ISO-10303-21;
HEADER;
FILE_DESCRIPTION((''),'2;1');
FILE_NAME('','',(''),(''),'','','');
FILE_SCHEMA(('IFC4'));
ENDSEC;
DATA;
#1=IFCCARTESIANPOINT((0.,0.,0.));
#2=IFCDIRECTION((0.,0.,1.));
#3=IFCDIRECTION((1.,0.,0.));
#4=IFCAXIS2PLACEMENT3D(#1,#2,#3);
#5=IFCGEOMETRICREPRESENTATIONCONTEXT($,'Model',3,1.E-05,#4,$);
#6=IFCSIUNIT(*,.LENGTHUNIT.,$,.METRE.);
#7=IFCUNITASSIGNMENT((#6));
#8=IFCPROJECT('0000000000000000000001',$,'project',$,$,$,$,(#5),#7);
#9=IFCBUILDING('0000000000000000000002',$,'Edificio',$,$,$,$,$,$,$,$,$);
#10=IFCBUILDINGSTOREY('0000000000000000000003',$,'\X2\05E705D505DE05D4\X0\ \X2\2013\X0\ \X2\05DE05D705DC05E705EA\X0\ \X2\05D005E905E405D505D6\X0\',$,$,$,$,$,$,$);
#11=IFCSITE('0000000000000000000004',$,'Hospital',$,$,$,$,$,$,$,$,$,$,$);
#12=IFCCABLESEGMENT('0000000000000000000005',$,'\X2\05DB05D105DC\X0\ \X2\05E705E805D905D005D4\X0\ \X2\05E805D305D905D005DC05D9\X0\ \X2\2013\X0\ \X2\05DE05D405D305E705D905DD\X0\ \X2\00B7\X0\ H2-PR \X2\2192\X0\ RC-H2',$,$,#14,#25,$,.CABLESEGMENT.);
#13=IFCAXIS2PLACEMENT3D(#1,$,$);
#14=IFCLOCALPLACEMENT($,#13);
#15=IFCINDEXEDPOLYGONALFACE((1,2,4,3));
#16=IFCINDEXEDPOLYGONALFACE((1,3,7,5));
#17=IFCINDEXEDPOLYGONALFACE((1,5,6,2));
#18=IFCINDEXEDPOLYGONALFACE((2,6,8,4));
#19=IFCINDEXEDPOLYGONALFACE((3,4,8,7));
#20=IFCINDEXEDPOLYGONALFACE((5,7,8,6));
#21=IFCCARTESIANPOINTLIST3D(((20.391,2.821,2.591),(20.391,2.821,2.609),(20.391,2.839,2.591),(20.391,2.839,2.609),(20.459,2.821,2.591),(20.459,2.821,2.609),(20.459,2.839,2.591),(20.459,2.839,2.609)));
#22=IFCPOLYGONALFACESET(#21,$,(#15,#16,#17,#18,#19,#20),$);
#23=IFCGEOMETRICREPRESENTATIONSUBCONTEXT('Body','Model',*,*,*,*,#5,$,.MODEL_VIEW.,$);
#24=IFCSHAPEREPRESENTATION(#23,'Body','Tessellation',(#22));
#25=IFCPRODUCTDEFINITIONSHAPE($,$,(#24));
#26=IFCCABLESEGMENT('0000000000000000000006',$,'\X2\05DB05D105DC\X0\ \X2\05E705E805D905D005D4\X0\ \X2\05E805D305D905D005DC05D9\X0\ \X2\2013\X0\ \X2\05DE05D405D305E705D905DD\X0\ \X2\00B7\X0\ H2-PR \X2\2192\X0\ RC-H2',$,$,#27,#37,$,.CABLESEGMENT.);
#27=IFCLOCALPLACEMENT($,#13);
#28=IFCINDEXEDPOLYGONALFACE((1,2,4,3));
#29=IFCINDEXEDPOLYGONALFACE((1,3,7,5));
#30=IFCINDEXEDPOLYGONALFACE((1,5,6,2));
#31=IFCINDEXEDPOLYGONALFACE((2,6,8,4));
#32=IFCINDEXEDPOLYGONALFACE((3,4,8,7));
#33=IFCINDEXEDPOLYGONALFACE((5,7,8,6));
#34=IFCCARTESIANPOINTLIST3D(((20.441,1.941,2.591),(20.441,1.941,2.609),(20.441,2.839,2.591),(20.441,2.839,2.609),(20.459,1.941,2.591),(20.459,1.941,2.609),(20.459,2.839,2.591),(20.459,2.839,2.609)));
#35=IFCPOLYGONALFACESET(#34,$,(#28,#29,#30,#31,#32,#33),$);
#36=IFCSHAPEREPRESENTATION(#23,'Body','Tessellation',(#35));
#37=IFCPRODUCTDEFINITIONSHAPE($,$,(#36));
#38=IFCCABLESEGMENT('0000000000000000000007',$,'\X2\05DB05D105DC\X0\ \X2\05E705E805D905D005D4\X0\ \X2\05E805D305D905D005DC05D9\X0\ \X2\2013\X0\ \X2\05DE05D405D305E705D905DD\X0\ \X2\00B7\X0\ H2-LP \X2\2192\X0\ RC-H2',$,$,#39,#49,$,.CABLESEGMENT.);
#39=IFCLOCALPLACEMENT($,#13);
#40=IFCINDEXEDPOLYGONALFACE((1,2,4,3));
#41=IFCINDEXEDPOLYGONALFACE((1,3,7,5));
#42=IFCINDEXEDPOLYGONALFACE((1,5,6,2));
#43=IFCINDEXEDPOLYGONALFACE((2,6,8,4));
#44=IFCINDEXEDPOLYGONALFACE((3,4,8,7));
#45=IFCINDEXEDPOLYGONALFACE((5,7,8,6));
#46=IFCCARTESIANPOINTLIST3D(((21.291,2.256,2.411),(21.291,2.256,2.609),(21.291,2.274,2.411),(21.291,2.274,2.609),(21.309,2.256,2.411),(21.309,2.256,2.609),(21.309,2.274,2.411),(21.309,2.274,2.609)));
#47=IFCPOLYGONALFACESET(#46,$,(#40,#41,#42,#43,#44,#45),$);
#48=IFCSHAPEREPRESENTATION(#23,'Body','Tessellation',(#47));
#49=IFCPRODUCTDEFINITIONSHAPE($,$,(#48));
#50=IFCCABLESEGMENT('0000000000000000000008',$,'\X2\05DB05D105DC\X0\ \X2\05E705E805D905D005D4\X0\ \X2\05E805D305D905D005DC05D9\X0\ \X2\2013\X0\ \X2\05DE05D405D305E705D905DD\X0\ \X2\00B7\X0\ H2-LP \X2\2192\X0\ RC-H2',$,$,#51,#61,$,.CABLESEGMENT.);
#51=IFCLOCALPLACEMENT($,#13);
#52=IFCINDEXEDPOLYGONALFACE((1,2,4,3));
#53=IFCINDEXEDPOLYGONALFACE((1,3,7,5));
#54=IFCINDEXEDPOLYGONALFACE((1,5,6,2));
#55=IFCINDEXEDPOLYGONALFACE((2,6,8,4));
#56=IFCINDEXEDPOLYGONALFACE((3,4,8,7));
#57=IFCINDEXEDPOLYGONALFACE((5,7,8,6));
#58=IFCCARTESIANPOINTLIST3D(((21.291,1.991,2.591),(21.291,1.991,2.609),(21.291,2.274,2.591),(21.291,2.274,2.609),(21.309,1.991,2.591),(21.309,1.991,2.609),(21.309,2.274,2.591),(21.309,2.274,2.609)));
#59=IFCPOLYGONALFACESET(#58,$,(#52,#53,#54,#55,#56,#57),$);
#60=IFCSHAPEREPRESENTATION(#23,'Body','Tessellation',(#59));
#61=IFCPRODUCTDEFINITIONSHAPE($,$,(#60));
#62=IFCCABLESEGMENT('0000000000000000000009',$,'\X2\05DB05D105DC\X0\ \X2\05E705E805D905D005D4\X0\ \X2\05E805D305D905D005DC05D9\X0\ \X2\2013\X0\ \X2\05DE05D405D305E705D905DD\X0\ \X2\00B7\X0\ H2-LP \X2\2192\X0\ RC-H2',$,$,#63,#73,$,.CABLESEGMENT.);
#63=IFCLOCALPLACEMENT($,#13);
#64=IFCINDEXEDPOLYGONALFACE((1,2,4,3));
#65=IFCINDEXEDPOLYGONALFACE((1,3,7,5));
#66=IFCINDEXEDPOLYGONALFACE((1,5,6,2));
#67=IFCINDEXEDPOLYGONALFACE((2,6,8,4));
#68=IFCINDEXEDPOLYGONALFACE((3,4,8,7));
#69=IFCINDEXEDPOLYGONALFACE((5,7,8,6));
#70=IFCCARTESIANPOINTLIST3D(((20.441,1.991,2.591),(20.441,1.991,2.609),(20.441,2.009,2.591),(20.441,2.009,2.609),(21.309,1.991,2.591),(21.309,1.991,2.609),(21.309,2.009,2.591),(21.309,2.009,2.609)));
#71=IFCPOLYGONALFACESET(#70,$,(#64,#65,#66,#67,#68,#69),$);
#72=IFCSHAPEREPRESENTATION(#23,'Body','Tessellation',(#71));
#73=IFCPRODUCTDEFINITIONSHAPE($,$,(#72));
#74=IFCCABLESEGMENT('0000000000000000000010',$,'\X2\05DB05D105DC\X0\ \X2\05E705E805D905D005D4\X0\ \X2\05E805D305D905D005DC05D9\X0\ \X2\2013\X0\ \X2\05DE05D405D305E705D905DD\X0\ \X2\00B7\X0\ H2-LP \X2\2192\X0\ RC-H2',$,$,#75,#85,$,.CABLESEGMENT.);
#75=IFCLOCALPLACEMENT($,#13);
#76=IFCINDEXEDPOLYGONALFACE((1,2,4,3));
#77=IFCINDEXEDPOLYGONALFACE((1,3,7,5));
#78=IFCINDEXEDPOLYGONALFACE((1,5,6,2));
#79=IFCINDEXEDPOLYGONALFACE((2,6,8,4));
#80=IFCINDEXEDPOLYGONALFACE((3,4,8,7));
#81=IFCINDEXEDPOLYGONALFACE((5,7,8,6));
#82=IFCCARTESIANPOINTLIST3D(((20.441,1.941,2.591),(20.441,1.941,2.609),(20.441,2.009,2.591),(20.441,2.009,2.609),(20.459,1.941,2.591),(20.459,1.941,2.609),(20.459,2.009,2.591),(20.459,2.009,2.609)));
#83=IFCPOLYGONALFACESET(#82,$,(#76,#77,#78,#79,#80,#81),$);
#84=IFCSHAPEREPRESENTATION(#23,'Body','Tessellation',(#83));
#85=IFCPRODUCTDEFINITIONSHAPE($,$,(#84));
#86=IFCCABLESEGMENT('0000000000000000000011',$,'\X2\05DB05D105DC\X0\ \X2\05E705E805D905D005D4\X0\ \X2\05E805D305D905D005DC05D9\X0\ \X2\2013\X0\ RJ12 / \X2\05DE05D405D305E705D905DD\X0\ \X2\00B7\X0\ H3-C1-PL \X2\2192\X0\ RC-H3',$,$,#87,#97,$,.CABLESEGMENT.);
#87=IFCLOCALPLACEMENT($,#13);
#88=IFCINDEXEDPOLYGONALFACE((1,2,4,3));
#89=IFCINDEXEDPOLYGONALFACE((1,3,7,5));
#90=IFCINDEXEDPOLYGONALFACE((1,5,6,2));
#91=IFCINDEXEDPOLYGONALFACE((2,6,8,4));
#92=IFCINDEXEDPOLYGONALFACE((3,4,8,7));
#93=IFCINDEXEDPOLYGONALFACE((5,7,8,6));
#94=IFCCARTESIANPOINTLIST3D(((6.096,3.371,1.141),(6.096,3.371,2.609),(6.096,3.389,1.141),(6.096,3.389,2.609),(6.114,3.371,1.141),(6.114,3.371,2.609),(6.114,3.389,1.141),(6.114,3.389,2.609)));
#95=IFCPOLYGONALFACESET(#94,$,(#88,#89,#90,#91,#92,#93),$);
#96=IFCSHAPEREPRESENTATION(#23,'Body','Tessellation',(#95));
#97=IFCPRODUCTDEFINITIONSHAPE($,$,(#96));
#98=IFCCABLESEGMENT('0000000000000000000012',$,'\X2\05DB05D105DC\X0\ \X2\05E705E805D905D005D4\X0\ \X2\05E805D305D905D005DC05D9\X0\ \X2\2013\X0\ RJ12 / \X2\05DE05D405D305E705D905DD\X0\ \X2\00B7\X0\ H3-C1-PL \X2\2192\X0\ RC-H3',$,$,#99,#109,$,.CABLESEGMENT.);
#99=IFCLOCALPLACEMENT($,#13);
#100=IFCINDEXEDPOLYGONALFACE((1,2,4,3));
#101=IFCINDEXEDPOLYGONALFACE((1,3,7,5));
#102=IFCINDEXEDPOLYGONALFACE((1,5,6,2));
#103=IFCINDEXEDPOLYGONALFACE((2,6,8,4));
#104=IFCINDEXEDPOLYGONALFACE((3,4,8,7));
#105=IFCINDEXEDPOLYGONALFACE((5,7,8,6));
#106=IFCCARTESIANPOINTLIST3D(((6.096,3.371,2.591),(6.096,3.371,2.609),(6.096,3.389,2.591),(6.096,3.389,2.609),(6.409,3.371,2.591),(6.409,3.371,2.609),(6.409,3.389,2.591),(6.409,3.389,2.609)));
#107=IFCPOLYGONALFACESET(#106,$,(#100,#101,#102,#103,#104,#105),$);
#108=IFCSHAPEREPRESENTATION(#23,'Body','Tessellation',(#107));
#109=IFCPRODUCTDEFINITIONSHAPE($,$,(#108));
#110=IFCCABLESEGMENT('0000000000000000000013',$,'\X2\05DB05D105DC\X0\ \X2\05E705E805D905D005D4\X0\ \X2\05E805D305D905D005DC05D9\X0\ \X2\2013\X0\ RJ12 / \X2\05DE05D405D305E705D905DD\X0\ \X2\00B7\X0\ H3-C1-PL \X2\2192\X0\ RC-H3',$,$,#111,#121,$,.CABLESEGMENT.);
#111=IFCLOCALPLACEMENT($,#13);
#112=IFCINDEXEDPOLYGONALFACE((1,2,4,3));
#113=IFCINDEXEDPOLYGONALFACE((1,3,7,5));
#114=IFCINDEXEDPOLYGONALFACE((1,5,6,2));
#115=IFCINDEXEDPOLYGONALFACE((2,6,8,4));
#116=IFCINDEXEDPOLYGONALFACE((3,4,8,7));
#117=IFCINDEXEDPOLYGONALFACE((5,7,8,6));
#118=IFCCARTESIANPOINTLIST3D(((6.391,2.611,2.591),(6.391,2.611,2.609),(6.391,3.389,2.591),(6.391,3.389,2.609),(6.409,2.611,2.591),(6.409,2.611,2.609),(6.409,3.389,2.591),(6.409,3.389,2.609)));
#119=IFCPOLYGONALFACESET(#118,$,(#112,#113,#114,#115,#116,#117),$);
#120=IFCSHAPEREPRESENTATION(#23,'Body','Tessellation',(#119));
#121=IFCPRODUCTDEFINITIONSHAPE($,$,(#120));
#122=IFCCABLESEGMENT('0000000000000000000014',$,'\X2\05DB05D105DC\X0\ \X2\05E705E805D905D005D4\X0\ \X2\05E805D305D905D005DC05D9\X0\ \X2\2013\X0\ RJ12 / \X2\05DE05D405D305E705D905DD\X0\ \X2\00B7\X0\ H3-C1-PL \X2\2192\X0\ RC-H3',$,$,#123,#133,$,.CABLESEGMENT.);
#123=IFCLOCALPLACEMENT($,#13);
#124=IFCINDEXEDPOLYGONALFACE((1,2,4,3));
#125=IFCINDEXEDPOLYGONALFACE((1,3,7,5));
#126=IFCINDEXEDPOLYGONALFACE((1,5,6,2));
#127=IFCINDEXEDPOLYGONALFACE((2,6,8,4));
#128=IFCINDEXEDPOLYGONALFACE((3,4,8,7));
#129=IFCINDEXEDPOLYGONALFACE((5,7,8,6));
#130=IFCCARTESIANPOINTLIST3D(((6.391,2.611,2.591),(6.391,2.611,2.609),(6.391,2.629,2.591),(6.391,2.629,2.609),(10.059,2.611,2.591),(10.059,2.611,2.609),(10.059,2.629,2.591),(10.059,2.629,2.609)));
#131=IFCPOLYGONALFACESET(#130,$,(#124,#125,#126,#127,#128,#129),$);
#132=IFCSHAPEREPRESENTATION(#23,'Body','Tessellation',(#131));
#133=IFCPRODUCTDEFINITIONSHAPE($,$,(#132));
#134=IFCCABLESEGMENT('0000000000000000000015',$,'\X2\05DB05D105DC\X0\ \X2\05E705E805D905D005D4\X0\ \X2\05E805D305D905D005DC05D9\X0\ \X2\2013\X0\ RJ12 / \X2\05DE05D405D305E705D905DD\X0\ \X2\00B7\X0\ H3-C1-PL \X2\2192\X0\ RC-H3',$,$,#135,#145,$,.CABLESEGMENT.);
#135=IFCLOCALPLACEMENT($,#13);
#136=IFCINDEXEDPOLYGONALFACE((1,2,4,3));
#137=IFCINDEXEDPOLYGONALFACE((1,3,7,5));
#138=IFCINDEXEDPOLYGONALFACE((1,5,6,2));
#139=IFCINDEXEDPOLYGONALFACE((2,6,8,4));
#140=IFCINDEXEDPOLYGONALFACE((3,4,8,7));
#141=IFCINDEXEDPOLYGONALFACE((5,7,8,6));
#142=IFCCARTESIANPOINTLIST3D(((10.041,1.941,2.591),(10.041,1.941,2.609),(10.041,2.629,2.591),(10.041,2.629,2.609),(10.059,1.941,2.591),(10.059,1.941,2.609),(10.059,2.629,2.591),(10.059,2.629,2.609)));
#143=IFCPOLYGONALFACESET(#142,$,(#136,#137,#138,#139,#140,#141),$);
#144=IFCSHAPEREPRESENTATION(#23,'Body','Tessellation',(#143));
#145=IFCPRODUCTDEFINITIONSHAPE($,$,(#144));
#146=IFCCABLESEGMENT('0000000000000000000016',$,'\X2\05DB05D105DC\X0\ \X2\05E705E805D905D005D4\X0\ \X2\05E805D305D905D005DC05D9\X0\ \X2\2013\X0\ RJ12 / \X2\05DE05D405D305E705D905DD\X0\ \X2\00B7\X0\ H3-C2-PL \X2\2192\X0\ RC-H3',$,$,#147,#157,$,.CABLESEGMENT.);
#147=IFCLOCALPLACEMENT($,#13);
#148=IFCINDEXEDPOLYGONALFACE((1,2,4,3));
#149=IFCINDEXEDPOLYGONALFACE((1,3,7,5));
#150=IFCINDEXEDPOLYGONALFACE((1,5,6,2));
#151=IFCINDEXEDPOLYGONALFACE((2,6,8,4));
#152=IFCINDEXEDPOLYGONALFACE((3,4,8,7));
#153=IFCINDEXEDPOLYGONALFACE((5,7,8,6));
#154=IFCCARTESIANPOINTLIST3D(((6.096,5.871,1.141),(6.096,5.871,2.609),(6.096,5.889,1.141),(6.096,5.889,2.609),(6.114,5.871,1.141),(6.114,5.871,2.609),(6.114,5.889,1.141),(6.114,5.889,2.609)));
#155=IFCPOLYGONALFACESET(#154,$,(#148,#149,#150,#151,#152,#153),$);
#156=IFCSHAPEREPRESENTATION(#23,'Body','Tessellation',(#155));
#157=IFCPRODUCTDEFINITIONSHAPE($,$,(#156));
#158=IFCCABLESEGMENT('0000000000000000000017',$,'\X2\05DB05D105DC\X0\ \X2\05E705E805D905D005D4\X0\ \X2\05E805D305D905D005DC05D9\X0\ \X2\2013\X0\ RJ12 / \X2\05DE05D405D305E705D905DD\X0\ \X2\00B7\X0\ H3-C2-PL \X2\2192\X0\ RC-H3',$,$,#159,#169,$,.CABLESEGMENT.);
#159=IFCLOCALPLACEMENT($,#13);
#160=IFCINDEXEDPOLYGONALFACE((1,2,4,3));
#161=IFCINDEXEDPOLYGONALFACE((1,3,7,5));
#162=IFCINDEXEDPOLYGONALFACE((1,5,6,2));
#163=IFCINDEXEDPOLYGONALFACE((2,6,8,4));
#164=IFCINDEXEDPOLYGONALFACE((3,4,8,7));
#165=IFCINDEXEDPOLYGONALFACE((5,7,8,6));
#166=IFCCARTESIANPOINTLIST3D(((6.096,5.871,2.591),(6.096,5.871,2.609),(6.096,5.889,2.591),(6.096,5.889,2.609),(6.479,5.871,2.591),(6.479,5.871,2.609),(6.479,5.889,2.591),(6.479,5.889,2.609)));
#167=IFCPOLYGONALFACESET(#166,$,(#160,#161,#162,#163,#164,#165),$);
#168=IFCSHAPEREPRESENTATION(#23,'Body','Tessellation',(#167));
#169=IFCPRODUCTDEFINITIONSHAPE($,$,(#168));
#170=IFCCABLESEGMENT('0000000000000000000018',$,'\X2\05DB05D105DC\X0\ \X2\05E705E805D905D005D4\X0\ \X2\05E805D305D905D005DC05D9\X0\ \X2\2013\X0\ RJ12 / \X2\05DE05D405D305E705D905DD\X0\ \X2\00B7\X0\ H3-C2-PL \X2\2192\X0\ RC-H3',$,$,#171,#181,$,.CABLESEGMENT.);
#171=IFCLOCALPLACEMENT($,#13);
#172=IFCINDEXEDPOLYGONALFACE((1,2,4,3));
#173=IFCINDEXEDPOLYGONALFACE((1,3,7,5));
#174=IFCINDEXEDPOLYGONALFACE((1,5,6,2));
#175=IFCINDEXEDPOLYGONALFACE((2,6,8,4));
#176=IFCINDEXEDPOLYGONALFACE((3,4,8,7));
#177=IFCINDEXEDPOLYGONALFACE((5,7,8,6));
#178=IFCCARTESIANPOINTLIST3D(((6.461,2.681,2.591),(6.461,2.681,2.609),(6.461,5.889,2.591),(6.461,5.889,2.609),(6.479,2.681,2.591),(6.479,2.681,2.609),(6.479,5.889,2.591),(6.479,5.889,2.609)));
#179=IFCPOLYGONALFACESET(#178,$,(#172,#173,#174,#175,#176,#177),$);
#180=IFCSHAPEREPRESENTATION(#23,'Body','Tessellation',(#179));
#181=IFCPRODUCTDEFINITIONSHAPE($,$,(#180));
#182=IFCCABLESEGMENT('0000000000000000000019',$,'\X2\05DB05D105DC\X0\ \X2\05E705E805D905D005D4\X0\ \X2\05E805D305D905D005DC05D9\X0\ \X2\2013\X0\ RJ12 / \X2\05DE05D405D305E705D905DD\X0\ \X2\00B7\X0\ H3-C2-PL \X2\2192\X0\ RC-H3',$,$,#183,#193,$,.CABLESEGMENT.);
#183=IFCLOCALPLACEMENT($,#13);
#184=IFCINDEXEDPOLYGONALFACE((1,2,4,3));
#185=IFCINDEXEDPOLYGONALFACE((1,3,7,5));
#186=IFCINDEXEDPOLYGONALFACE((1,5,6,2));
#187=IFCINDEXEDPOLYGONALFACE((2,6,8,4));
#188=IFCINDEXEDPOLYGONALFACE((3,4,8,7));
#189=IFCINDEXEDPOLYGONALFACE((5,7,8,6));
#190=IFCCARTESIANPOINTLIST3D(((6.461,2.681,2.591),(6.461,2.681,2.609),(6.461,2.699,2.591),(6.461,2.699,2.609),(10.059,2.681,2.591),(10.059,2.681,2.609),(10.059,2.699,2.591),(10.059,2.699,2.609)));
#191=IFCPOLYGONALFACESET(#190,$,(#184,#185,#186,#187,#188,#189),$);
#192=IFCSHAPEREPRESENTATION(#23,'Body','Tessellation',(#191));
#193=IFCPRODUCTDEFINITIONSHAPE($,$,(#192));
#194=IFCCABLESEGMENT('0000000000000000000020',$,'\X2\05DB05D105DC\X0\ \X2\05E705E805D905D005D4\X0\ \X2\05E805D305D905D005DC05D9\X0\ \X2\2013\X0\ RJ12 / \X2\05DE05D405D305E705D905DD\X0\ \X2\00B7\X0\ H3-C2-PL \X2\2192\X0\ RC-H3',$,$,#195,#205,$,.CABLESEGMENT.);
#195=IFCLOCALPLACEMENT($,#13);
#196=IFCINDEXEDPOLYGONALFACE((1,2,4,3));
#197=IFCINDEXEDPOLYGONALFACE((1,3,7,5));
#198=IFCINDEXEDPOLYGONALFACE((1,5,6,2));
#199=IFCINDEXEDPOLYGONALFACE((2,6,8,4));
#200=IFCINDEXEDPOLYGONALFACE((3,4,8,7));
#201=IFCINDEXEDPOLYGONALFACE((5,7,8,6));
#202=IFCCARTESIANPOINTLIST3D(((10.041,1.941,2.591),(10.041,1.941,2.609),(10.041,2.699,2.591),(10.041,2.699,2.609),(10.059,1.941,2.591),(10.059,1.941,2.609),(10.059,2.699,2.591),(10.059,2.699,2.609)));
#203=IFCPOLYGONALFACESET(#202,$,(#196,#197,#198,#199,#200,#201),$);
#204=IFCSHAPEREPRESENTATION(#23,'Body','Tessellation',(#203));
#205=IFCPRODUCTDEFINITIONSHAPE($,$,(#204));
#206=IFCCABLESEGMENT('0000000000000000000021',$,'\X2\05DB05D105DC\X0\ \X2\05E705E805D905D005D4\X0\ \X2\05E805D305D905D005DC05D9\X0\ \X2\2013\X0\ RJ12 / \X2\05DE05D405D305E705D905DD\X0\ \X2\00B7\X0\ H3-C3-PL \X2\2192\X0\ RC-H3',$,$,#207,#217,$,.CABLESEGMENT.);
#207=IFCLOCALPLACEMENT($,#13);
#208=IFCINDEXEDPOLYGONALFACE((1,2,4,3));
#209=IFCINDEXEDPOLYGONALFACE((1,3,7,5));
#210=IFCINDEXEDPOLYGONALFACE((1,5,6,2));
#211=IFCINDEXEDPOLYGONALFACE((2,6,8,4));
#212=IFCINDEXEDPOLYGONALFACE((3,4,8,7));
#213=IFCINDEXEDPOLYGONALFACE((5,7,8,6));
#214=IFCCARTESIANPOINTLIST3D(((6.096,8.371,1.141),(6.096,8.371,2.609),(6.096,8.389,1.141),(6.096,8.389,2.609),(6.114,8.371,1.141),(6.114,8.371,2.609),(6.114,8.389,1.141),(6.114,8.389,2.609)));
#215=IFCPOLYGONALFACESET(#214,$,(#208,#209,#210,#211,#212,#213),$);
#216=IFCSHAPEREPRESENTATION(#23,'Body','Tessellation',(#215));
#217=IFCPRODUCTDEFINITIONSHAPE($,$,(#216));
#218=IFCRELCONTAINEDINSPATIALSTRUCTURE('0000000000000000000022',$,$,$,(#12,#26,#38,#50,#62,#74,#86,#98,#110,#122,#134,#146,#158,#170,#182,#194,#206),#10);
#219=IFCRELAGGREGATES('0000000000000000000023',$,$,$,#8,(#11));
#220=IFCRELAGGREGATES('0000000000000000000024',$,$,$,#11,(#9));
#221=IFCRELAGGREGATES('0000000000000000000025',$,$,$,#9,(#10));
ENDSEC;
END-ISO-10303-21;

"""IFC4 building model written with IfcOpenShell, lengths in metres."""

from ifc_helpers import new_model, si_unit, frame, origin_with_axes, context, subcontext, project, spatial, line, indexed_curve, outline, extrude, element, save


model = new_model("IFC4")

# Units and contexts
model_context = context("Model", 3, precision=1e-05, world=origin_with_axes())
body_context = subcontext(model_context, "Body", "Model", "MODEL_VIEW")
ifc_project = project(units=[si_unit("LENGTHUNIT", "METRE")], contexts=[model_context])

# Site, building, storey
site = spatial("IfcSite", under=ifc_project, Name="Hospital")
building = spatial("IfcBuilding", under=site, Name="Edificio")
storey = spatial("IfcBuildingStorey", under=building, Name="קומה – מחלקת אשפוז")

# Cable segments
element("IfcCableSegment", 1, inside=storey, Name="כבל קריאה רדיאלי – מהדקים · H2-PR → RC-H2", PredefinedType="CABLESEGMENT", context=body_context, shape_type="SweptSolid", body=[
    extrude(outline(indexed_curve([(0.0, 0.0), (0.068, 0.0), (0.068, 0.018), (0.0, 0.018)], segments=[line(1, 2, 3, 4, 1)])), frame((20.391, 2.821, 2.591), z_axis=(0.0, 0.0, 1.0), x_axis=(1.0, 0.0, 0.0)), (0.0, 0.0, 1.0), 0.018),
])
element("IfcCableSegment", 2, inside=storey, Name="כבל קריאה רדיאלי – מהדקים · H2-PR → RC-H2", PredefinedType="CABLESEGMENT", context=body_context, shape_type="SweptSolid", body=[
    extrude(outline(indexed_curve([(0.0, 0.0), (0.018, 0.0), (0.018, 0.898), (0.0, 0.898)], segments=[line(1, 2, 3, 4, 1)])), frame((20.441, 1.941, 2.591), z_axis=(0.0, 0.0, 1.0), x_axis=(1.0, 0.0, 0.0)), (0.0, 0.0, 1.0), 0.018),
])
element("IfcCableSegment", 3, inside=storey, Name="כבל קריאה רדיאלי – מהדקים · H2-LP → RC-H2", PredefinedType="CABLESEGMENT", context=body_context, shape_type="SweptSolid", body=[
    extrude(outline(indexed_curve([(0.0, 0.0), (0.018, 0.0), (0.018, 0.018), (0.0, 0.018)], segments=[line(1, 2, 3, 4, 1)])), frame((21.291, 2.256, 2.411), z_axis=(0.0, 0.0, 1.0), x_axis=(1.0, 0.0, 0.0)), (0.0, 0.0, 1.0), 0.198),
])
element("IfcCableSegment", 4, inside=storey, Name="כבל קריאה רדיאלי – מהדקים · H2-LP → RC-H2", PredefinedType="CABLESEGMENT", context=body_context, shape_type="SweptSolid", body=[
    extrude(outline(indexed_curve([(0.0, 0.0), (0.018, 0.0), (0.018, 0.283), (0.0, 0.283)], segments=[line(1, 2, 3, 4, 1)])), frame((21.291, 1.991, 2.591), z_axis=(0.0, 0.0, 1.0), x_axis=(1.0, 0.0, 0.0)), (0.0, 0.0, 1.0), 0.018),
])
element("IfcCableSegment", 5, inside=storey, Name="כבל קריאה רדיאלי – מהדקים · H2-LP → RC-H2", PredefinedType="CABLESEGMENT", context=body_context, shape_type="SweptSolid", body=[
    extrude(outline(indexed_curve([(0.0, 0.0), (0.868, 0.0), (0.868, 0.018), (0.0, 0.018)], segments=[line(1, 2, 3, 4, 1)])), frame((20.441, 1.991, 2.591), z_axis=(0.0, 0.0, 1.0), x_axis=(1.0, 0.0, 0.0)), (0.0, 0.0, 1.0), 0.018),
])
element("IfcCableSegment", 6, inside=storey, Name="כבל קריאה רדיאלי – מהדקים · H2-LP → RC-H2", PredefinedType="CABLESEGMENT", context=body_context, shape_type="SweptSolid", body=[
    extrude(outline(indexed_curve([(0.0, 0.0), (0.018, 0.0), (0.018, 0.068), (0.0, 0.068)], segments=[line(1, 2, 3, 4, 1)])), frame((20.441, 1.941, 2.591), z_axis=(0.0, 0.0, 1.0), x_axis=(1.0, 0.0, 0.0)), (0.0, 0.0, 1.0), 0.018),
])
element("IfcCableSegment", 7, inside=storey, Name="כבל קריאה רדיאלי – RJ12 / מהדקים · H3-C1-PL → RC-H3", PredefinedType="CABLESEGMENT", context=body_context, shape_type="SweptSolid", body=[
    extrude(outline(indexed_curve([(0.0, 0.0), (0.018, 0.0), (0.018, 0.018), (0.0, 0.018)], segments=[line(1, 2, 3, 4, 1)])), frame((6.096, 3.371, 1.141), z_axis=(0.0, 0.0, 1.0), x_axis=(1.0, 0.0, 0.0)), (0.0, 0.0, 1.0), 1.468),
])
element("IfcCableSegment", 8, inside=storey, Name="כבל קריאה רדיאלי – RJ12 / מהדקים · H3-C1-PL → RC-H3", PredefinedType="CABLESEGMENT", context=body_context, shape_type="SweptSolid", body=[
    extrude(outline(indexed_curve([(0.0, 0.0), (0.313, 0.0), (0.313, 0.018), (0.0, 0.018)], segments=[line(1, 2, 3, 4, 1)])), frame((6.096, 3.371, 2.591), z_axis=(0.0, 0.0, 1.0), x_axis=(1.0, 0.0, 0.0)), (0.0, 0.0, 1.0), 0.018),
])
element("IfcCableSegment", 9, inside=storey, Name="כבל קריאה רדיאלי – RJ12 / מהדקים · H3-C1-PL → RC-H3", PredefinedType="CABLESEGMENT", context=body_context, shape_type="SweptSolid", body=[
    extrude(outline(indexed_curve([(0.0, 0.0), (0.018, 0.0), (0.018, 0.778), (0.0, 0.778)], segments=[line(1, 2, 3, 4, 1)])), frame((6.391, 2.611, 2.591), z_axis=(0.0, 0.0, 1.0), x_axis=(1.0, 0.0, 0.0)), (0.0, 0.0, 1.0), 0.018),
])
element("IfcCableSegment", 10, inside=storey, Name="כבל קריאה רדיאלי – RJ12 / מהדקים · H3-C1-PL → RC-H3", PredefinedType="CABLESEGMENT", context=body_context, shape_type="SweptSolid", body=[
    extrude(outline(indexed_curve([(0.0, 0.0), (3.668, 0.0), (3.668, 0.018), (0.0, 0.018)], segments=[line(1, 2, 3, 4, 1)])), frame((6.391, 2.611, 2.591), z_axis=(0.0, 0.0, 1.0), x_axis=(1.0, 0.0, 0.0)), (0.0, 0.0, 1.0), 0.018),
])
element("IfcCableSegment", 11, inside=storey, Name="כבל קריאה רדיאלי – RJ12 / מהדקים · H3-C1-PL → RC-H3", PredefinedType="CABLESEGMENT", context=body_context, shape_type="SweptSolid", body=[
    extrude(outline(indexed_curve([(0.0, 0.0), (0.018, 0.0), (0.018, 0.688), (0.0, 0.688)], segments=[line(1, 2, 3, 4, 1)])), frame((10.041, 1.941, 2.591), z_axis=(0.0, 0.0, 1.0), x_axis=(1.0, 0.0, 0.0)), (0.0, 0.0, 1.0), 0.018),
])
element("IfcCableSegment", 12, inside=storey, Name="כבל קריאה רדיאלי – RJ12 / מהדקים · H3-C2-PL → RC-H3", PredefinedType="CABLESEGMENT", context=body_context, shape_type="SweptSolid", body=[
    extrude(outline(indexed_curve([(0.0, 0.0), (0.018, 0.0), (0.018, 0.018), (0.0, 0.018)], segments=[line(1, 2, 3, 4, 1)])), frame((6.096, 5.871, 1.141), z_axis=(0.0, 0.0, 1.0), x_axis=(1.0, 0.0, 0.0)), (0.0, 0.0, 1.0), 1.468),
])
element("IfcCableSegment", 13, inside=storey, Name="כבל קריאה רדיאלי – RJ12 / מהדקים · H3-C2-PL → RC-H3", PredefinedType="CABLESEGMENT", context=body_context, shape_type="SweptSolid", body=[
    extrude(outline(indexed_curve([(0.0, 0.0), (0.383, 0.0), (0.383, 0.018), (0.0, 0.018)], segments=[line(1, 2, 3, 4, 1)])), frame((6.096, 5.871, 2.591), z_axis=(0.0, 0.0, 1.0), x_axis=(1.0, 0.0, 0.0)), (0.0, 0.0, 1.0), 0.018),
])
element("IfcCableSegment", 14, inside=storey, Name="כבל קריאה רדיאלי – RJ12 / מהדקים · H3-C2-PL → RC-H3", PredefinedType="CABLESEGMENT", context=body_context, shape_type="SweptSolid", body=[
    extrude(outline(indexed_curve([(0.0, 0.0), (0.018, 0.0), (0.018, 3.208), (0.0, 3.208)], segments=[line(1, 2, 3, 4, 1)])), frame((6.461, 2.681, 2.591), z_axis=(0.0, 0.0, 1.0), x_axis=(1.0, 0.0, 0.0)), (0.0, 0.0, 1.0), 0.018),
])
element("IfcCableSegment", 15, inside=storey, Name="כבל קריאה רדיאלי – RJ12 / מהדקים · H3-C2-PL → RC-H3", PredefinedType="CABLESEGMENT", context=body_context, shape_type="SweptSolid", body=[
    extrude(outline(indexed_curve([(0.0, 0.0), (3.598, 0.0), (3.598, 0.018), (0.0, 0.018)], segments=[line(1, 2, 3, 4, 1)])), frame((6.461, 2.681, 2.591), z_axis=(0.0, 0.0, 1.0), x_axis=(1.0, 0.0, 0.0)), (0.0, 0.0, 1.0), 0.018),
])
element("IfcCableSegment", 16, inside=storey, Name="כבל קריאה רדיאלי – RJ12 / מהדקים · H3-C2-PL → RC-H3", PredefinedType="CABLESEGMENT", context=body_context, shape_type="SweptSolid", body=[
    extrude(outline(indexed_curve([(0.0, 0.0), (0.018, 0.0), (0.018, 0.758), (0.0, 0.758)], segments=[line(1, 2, 3, 4, 1)])), frame((10.041, 1.941, 2.591), z_axis=(0.0, 0.0, 1.0), x_axis=(1.0, 0.0, 0.0)), (0.0, 0.0, 1.0), 0.018),
])
element("IfcCableSegment", 17, inside=storey, Name="כבל קריאה רדיאלי – RJ12 / מהדקים · H3-C3-PL → RC-H3", PredefinedType="CABLESEGMENT", context=body_context, shape_type="SweptSolid", body=[
    extrude(outline(indexed_curve([(0.0, 0.0), (0.018, 0.0), (0.018, 0.018), (0.0, 0.018)], segments=[line(1, 2, 3, 4, 1)])), frame((6.096, 8.371, 1.141), z_axis=(0.0, 0.0, 1.0), x_axis=(1.0, 0.0, 0.0)), (0.0, 0.0, 1.0), 1.468),
])

save(model, "model.ifc")
